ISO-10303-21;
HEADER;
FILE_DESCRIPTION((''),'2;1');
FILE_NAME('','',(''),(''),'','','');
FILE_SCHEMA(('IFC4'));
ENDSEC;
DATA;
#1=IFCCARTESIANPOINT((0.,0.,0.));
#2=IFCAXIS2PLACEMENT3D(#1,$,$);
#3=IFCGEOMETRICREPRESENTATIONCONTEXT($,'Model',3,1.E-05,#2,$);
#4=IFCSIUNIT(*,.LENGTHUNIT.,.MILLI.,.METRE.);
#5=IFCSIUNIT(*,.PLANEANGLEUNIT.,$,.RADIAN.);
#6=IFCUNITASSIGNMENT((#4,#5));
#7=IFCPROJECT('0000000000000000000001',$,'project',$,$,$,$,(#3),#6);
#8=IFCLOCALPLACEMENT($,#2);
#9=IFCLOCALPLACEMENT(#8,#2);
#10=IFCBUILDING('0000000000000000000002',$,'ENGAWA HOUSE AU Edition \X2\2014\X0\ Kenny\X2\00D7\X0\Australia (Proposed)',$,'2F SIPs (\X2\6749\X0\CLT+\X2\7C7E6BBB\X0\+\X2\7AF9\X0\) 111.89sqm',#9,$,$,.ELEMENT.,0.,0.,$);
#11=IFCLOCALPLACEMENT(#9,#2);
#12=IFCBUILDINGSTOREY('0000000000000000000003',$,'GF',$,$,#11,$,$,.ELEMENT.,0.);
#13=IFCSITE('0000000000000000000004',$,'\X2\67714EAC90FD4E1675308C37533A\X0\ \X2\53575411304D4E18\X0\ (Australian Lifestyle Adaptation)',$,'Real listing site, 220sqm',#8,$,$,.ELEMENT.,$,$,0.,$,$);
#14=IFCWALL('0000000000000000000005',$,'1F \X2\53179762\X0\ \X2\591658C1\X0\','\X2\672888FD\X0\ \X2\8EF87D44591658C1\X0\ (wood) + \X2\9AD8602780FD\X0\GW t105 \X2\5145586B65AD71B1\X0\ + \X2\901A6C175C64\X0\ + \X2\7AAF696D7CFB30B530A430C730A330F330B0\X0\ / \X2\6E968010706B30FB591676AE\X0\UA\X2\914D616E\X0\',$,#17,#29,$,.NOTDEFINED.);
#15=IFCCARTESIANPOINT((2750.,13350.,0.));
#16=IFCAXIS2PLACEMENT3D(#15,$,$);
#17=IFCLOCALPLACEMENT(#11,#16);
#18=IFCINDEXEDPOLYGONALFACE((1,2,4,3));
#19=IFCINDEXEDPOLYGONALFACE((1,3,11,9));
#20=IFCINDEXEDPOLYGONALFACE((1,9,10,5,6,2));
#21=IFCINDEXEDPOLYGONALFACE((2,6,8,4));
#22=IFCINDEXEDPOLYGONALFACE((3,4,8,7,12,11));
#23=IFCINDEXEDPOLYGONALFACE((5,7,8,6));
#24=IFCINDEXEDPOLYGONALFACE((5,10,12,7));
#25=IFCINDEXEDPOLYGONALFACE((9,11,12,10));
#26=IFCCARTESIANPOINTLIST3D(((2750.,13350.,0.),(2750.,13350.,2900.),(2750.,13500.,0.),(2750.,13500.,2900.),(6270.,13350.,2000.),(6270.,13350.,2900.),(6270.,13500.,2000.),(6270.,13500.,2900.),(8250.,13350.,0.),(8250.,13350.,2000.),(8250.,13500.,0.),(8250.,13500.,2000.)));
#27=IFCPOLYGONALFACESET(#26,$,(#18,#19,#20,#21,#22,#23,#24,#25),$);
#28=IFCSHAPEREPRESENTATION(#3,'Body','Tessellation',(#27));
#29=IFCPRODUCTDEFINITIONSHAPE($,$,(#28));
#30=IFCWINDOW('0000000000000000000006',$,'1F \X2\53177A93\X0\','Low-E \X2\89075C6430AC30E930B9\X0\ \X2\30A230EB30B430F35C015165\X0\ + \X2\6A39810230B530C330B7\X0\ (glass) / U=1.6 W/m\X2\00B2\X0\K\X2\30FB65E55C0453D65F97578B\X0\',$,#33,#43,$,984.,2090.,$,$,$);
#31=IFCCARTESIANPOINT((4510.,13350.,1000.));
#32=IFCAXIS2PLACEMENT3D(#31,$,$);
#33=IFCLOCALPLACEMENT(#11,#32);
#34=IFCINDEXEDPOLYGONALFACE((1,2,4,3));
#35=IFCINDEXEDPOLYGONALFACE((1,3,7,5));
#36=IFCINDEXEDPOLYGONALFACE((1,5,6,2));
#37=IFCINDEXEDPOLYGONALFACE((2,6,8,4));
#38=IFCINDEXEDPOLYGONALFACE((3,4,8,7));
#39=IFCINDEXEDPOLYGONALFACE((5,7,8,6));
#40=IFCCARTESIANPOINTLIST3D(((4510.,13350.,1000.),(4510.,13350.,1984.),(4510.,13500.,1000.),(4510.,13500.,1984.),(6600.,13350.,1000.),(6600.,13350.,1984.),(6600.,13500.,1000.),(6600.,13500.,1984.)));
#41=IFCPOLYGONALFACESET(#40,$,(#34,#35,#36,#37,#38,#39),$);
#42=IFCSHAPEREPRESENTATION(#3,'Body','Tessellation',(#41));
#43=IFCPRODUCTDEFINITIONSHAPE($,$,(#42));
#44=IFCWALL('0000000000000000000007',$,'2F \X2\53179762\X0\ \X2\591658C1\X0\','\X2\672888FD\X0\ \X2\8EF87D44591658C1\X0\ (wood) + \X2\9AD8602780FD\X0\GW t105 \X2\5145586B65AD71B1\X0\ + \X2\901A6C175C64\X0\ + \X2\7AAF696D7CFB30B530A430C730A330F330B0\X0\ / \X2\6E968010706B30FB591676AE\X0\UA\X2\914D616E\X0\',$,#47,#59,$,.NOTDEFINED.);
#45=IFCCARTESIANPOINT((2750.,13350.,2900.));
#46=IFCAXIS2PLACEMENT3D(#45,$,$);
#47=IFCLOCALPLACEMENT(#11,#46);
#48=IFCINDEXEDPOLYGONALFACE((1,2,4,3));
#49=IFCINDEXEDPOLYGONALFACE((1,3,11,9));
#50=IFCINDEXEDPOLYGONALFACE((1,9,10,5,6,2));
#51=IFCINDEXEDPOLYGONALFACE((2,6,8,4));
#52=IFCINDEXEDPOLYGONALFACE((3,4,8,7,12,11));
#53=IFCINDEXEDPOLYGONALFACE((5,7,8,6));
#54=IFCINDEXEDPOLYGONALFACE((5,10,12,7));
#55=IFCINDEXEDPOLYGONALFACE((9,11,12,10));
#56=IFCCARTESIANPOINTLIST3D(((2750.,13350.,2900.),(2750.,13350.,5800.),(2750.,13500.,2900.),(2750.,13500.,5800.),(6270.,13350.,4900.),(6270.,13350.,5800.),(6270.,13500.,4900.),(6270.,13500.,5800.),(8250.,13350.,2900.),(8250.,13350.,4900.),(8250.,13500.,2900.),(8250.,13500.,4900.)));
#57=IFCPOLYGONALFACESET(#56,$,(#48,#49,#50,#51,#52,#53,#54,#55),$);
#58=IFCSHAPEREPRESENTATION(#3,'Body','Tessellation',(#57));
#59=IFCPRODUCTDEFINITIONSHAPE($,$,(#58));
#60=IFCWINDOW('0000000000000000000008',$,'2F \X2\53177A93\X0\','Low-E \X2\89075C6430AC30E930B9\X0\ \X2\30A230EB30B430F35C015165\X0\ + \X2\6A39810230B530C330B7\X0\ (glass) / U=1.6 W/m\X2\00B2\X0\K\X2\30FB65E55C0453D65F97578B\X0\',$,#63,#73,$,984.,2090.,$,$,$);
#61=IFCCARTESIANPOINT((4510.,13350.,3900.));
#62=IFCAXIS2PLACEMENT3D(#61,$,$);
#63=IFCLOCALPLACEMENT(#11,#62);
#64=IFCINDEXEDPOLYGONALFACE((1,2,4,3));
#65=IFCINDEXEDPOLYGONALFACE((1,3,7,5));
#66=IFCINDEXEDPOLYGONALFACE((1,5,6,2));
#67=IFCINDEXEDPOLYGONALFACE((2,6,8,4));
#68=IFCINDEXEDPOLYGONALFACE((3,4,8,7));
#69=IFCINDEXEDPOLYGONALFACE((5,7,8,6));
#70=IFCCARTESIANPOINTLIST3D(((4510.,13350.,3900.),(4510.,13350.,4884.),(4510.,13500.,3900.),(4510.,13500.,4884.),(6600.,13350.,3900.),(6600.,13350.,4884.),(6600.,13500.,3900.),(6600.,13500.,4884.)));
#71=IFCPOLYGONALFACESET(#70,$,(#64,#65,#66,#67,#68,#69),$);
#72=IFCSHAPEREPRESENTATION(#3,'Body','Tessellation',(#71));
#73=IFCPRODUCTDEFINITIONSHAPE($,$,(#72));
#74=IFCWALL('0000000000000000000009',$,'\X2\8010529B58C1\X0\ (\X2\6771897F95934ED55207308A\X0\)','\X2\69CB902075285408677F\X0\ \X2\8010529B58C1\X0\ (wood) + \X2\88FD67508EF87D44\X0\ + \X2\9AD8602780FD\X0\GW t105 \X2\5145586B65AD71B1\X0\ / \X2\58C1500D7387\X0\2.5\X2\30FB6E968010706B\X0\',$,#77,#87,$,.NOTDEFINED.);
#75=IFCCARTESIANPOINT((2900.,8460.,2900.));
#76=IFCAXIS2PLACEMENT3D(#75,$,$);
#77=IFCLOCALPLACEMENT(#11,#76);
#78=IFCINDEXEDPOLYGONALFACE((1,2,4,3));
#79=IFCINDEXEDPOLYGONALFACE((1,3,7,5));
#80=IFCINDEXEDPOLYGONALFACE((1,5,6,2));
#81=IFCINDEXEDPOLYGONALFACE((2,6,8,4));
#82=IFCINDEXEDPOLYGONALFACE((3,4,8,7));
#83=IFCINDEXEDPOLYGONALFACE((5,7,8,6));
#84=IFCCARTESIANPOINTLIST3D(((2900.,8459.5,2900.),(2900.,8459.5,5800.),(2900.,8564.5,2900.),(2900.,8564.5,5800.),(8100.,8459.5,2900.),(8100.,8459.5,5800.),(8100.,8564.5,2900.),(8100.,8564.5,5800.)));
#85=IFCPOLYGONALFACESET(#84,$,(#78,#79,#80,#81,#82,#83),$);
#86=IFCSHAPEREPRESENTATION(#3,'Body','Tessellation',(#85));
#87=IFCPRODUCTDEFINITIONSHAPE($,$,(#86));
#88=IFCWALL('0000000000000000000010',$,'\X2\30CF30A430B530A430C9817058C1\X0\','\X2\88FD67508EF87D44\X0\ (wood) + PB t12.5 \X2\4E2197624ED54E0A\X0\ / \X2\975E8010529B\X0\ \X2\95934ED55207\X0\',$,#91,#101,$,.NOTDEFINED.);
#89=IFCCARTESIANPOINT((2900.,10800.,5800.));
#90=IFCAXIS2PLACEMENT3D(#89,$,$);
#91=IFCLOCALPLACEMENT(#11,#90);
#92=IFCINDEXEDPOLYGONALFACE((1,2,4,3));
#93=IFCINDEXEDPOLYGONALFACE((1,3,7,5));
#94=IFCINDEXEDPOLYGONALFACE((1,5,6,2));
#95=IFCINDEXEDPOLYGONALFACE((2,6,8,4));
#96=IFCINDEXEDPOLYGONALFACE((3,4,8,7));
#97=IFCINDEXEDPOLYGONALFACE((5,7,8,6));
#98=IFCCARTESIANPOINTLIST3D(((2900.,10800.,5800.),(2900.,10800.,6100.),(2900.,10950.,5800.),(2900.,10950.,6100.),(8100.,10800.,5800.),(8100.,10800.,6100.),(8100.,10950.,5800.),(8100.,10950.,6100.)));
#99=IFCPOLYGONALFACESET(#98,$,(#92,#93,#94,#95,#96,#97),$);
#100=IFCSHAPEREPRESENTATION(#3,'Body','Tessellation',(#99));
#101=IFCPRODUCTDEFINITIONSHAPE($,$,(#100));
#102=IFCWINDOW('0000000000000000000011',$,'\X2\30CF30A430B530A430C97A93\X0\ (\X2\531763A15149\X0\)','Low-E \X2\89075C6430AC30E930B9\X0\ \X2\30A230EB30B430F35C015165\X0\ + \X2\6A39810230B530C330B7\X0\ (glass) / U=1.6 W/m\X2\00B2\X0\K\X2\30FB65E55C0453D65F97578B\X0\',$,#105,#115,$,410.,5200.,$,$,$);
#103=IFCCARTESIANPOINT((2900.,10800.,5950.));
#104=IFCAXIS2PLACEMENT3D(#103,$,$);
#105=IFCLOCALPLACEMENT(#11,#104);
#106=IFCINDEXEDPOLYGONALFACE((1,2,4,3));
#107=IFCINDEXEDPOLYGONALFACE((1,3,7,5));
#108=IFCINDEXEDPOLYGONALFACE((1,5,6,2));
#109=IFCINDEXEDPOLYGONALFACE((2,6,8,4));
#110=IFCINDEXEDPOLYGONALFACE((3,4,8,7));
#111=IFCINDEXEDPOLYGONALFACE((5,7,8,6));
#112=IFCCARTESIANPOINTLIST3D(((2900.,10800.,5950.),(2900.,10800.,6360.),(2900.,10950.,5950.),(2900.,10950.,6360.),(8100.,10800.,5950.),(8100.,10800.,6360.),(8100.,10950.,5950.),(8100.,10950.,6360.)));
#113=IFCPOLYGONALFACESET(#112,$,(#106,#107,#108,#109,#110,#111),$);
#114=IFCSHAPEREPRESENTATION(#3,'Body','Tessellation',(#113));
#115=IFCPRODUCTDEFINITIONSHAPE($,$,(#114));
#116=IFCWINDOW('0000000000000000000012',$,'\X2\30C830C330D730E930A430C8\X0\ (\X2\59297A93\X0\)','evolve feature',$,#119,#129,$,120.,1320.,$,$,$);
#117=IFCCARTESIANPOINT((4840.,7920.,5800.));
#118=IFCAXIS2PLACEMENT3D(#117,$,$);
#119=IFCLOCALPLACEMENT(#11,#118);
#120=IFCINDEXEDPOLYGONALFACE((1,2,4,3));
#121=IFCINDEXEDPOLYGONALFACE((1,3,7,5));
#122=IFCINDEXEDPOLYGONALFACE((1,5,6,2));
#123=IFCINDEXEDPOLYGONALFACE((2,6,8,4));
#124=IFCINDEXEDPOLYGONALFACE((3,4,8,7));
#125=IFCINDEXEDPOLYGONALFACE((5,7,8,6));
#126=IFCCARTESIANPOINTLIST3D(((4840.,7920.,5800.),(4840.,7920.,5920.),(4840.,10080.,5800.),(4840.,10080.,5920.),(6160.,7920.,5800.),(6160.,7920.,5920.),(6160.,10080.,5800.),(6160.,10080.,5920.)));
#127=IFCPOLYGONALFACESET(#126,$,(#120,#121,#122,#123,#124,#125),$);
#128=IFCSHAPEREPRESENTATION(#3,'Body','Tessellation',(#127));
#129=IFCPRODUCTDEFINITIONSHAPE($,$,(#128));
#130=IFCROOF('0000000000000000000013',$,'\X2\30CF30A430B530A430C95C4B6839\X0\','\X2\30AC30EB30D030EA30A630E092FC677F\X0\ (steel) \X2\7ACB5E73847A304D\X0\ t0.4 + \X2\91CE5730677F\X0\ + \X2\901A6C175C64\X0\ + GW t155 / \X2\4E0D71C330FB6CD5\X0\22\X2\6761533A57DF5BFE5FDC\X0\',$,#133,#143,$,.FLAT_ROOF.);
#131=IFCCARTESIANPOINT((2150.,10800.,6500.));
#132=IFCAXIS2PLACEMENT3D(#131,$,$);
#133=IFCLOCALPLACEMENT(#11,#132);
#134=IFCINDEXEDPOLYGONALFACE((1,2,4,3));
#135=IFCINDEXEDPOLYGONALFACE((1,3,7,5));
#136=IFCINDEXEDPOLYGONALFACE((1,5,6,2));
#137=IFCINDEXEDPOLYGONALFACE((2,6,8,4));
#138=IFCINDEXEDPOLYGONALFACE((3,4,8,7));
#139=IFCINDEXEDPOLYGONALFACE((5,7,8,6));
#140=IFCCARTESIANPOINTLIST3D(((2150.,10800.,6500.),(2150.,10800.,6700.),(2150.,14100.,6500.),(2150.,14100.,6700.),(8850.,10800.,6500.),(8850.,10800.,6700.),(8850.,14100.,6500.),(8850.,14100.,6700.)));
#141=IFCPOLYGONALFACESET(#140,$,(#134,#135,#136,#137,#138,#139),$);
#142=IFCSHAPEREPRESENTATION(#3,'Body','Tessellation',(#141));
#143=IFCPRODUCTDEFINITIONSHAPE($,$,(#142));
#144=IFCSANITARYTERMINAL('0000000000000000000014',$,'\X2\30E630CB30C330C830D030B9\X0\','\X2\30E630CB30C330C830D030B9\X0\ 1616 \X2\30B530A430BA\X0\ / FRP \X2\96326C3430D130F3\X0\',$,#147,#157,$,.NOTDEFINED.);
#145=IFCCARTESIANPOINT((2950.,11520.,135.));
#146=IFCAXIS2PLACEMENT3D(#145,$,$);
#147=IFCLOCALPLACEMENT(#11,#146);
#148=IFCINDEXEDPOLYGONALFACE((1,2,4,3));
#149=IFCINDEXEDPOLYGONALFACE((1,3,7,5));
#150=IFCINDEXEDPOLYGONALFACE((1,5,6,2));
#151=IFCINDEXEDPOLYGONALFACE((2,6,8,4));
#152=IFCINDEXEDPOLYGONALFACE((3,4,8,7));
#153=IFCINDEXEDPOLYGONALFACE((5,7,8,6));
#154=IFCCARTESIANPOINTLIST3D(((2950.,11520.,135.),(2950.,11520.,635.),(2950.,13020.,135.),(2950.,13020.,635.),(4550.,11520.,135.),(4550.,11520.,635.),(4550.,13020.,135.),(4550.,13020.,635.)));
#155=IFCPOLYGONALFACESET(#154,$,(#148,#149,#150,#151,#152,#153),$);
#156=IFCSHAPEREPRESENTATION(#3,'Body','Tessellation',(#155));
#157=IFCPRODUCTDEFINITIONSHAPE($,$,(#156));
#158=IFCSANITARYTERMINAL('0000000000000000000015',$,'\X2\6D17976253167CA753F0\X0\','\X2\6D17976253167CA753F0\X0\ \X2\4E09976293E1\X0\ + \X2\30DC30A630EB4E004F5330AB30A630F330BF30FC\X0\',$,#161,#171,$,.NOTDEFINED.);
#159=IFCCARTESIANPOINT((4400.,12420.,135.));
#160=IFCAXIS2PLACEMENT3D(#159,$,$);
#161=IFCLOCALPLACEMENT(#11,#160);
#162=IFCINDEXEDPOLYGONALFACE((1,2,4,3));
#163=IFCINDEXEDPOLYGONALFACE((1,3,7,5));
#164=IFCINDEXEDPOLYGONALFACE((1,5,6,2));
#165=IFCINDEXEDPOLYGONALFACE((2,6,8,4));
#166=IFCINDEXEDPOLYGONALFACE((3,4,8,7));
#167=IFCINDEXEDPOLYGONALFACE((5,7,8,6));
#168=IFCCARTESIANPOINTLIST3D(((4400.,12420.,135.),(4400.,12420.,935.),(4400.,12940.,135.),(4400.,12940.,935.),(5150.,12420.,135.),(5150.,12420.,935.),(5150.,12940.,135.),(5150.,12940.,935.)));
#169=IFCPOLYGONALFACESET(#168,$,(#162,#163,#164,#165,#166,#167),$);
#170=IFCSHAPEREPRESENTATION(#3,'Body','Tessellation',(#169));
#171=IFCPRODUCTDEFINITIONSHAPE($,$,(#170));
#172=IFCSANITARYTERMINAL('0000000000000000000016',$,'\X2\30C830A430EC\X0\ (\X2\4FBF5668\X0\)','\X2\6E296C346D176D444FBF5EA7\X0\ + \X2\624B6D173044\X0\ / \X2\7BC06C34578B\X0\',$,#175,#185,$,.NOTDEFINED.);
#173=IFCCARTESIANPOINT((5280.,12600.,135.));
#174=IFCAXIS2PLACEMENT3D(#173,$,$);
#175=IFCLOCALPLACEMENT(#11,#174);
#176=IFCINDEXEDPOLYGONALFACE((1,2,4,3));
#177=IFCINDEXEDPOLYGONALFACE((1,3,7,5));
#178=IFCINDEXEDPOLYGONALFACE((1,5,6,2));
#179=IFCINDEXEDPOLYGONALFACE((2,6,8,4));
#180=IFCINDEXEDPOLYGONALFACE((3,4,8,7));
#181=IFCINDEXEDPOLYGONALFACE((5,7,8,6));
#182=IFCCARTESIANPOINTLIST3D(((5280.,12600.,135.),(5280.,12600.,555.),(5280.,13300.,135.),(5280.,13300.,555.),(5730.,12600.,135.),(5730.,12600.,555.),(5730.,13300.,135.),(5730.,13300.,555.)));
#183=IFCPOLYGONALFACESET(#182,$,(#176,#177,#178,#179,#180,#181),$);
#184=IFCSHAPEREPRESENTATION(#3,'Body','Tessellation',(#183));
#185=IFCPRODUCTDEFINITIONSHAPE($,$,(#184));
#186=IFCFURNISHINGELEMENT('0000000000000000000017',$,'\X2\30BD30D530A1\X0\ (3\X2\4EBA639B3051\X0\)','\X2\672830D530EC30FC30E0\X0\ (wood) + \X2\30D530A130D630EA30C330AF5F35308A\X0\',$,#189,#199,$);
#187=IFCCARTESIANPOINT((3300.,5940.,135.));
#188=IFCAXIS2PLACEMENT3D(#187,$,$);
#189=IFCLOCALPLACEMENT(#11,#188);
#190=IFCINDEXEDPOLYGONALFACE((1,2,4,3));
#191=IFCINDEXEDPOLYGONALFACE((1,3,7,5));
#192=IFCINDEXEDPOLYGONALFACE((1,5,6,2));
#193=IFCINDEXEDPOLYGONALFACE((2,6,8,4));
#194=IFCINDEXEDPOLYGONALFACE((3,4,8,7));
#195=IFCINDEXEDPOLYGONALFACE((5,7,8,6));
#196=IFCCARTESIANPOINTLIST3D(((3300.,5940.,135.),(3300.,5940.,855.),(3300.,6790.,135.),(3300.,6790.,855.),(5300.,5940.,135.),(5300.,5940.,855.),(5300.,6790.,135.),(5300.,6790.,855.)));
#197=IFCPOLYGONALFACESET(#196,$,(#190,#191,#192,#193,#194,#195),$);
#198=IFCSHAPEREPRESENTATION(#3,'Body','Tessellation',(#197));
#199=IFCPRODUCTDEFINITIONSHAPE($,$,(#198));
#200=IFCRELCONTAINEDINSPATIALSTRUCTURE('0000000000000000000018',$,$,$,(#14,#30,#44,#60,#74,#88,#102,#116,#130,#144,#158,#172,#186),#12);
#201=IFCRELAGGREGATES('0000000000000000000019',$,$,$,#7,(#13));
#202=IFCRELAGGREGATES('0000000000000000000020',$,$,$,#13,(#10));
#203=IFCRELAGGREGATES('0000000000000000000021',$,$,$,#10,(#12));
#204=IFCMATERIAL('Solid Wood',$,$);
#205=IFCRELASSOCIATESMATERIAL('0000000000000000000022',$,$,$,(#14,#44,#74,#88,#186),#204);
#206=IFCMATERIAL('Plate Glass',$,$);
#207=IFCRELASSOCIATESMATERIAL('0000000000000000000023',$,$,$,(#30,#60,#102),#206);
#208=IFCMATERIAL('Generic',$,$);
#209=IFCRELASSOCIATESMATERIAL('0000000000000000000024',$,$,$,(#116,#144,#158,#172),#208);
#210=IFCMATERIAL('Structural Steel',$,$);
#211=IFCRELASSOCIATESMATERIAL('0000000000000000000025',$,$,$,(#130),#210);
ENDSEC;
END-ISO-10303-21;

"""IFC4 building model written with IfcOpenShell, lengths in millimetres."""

from ifc_helpers import new_model, si_unit, frame, frame_2d, origin, place, context, project, spatial, rectangle, extrude, material, element, fill, save


model = new_model("IFC4")

# Units and contexts
model_context = context("Model", 3, precision=1e-05, world=origin())
ifc_project = project(units=[si_unit("LENGTHUNIT", "METRE", prefix="MILLI"), si_unit("PLANEANGLEUNIT", "RADIAN")], contexts=[model_context])

# Site, building, storey
site_placement = place(None, origin())
site = spatial("IfcSite", under=ifc_project, at=site_placement, Name="東京都世田谷区 南向き丘 (Australian Lifestyle Adaptation)", ObjectType="Real listing site, 220sqm", CompositionType="ELEMENT", RefElevation=0.0)
building_placement = place(site_placement, origin())
building = spatial("IfcBuilding", under=site, at=building_placement, Name="ENGAWA HOUSE AU Edition — Kenny×Australia (Proposed)", ObjectType="2F SIPs (杉CLT+籾殻+竹) 111.89sqm", CompositionType="ELEMENT", ElevationOfRefHeight=0.0, ElevationOfTerrain=0.0)
storey_placement = place(building_placement, origin())
storey = spatial("IfcBuildingStorey", under=building, at=storey_placement, Name="GF", CompositionType="ELEMENT", Elevation=0.0)

# Wall, opening, window
ifc_material_1 = material(Name="Solid Wood")
wall_1_placement = place(storey_placement, frame((2750.0, 13350.0, 0.0)))
wall_1 = element("IfcWall", 1, at=wall_1_placement, inside=storey, material=ifc_material_1, Name="1F 北面 外壁", Description="木製 軸組外壁 (wood) + 高性能GW t105 充填断熱 + 通気層 + 窯業系サイディング / 準耐火・外皮UA配慮", PredefinedType="NOTDEFINED", context=model_context, shape_type="SweptSolid", body=[
    extrude(rectangle(XDim=5500.0, YDim=150.0, at=frame_2d((2750.0, 75.0))), frame((2750.0, 13350.0, 0.0)), (0.0, 0.0, 1.0), 2900.0),
])
opening_1_placement = place(storey_placement, frame((4510.0, 13350.0, 1000.0)))
opening_1 = element("IfcOpeningElement", 2, at=opening_1_placement, cuts=wall_1, PredefinedType="NOTDEFINED", context=model_context, shape_type="SweptSolid", body=[
    extrude(rectangle(XDim=2090.0, YDim=150.0, at=frame_2d((1045.0, 75.0))), frame((4510.0, 13350.0, 1000.0)), (0.0, 0.0, 1.0), 984.0),
])
ifc_material_2 = material(Name="Plate Glass")
window_1_placement = place(storey_placement, frame((4510.0, 13350.0, 1000.0)))
window_1 = element("IfcWindow", 3, at=window_1_placement, inside=storey, material=ifc_material_2, Name="1F 北窓", Description="Low-E 複層ガラス アルゴン封入 + 樹脂サッシ (glass) / U=1.6 W/m²K・日射取得型", OverallHeight=984.0, OverallWidth=2090.0, context=model_context, shape_type="SweptSolid", body=[
    extrude(rectangle(XDim=2090.0, YDim=150.0, at=frame_2d((1045.0, 75.0))), frame((4510.0, 13350.0, 1000.0)), (0.0, 0.0, 1.0), 984.0),
])
fill(opening_1, window_1)

# Wall, opening, window
wall_2_placement = place(storey_placement, frame((2750.0, 13350.0, 2900.0)))
wall_2 = element("IfcWall", 4, at=wall_2_placement, inside=storey, material=ifc_material_1, Name="2F 北面 外壁", Description="木製 軸組外壁 (wood) + 高性能GW t105 充填断熱 + 通気層 + 窯業系サイディング / 準耐火・外皮UA配慮", PredefinedType="NOTDEFINED", context=model_context, shape_type="SweptSolid", body=[
    extrude(rectangle(XDim=5500.0, YDim=150.0, at=frame_2d((2750.0, 75.0))), frame((2750.0, 13350.0, 2900.0)), (0.0, 0.0, 1.0), 2900.0),
])
opening_2_placement = place(storey_placement, frame((4510.0, 13350.0, 3900.0)))
opening_2 = element("IfcOpeningElement", 5, at=opening_2_placement, cuts=wall_2, PredefinedType="NOTDEFINED", context=model_context, shape_type="SweptSolid", body=[
    extrude(rectangle(XDim=2090.0, YDim=150.0, at=frame_2d((1045.0, 75.0))), frame((4510.0, 13350.0, 3900.0)), (0.0, 0.0, 1.0), 984.0),
])
window_2_placement = place(storey_placement, frame((4510.0, 13350.0, 3900.0)))
window_2 = element("IfcWindow", 6, at=window_2_placement, inside=storey, material=ifc_material_2, Name="2F 北窓", Description="Low-E 複層ガラス アルゴン封入 + 樹脂サッシ (glass) / U=1.6 W/m²K・日射取得型", OverallHeight=984.0, OverallWidth=2090.0, context=model_context, shape_type="SweptSolid", body=[
    extrude(rectangle(XDim=2090.0, YDim=150.0, at=frame_2d((1045.0, 75.0))), frame((4510.0, 13350.0, 3900.0)), (0.0, 0.0, 1.0), 984.0),
])
fill(opening_2, window_2)

# Wall
wall_3_placement = place(storey_placement, frame((2900.0, 8460.0, 2900.0)))
element("IfcWall", 7, at=wall_3_placement, inside=storey, material=ifc_material_1, Name="耐力壁 (東西間仕切り)", Description="構造用合板 耐力壁 (wood) + 製材軸組 + 高性能GW t105 充填断熱 / 壁倍率2.5・準耐火", PredefinedType="NOTDEFINED", context=model_context, shape_type="SweptSolid", body=[
    extrude(rectangle(XDim=5200.0, YDim=105.0, at=frame_2d((2600.0, 52.0))), frame((2900.0, 8460.0, 2900.0)), (0.0, 0.0, 1.0), 2900.0),
])

# Wall, opening, window
wall_4_placement = place(storey_placement, frame((2900.0, 10800.0, 5800.0)))
wall_4 = element("IfcWall", 8, at=wall_4_placement, inside=storey, material=ifc_material_1, Name="ハイサイド腰壁", Description="製材軸組 (wood) + PB t12.5 両面仕上 / 非耐力 間仕切", PredefinedType="NOTDEFINED", context=model_context, shape_type="SweptSolid", body=[
    extrude(rectangle(XDim=5200.0, YDim=150.0, at=frame_2d((2600.0, 75.0))), frame((2900.0, 10800.0, 5800.0)), (0.0, 0.0, 1.0), 700.0),
])
opening_3_placement = place(storey_placement, frame((2900.0, 10800.0, 5950.0)))
opening_3 = element("IfcOpeningElement", 9, at=opening_3_placement, cuts=wall_4, PredefinedType="NOTDEFINED", context=model_context, shape_type="SweptSolid", body=[
    extrude(rectangle(XDim=5200.0, YDim=150.0, at=frame_2d((2600.0, 75.0))), frame((2900.0, 10800.0, 5950.0)), (0.0, 0.0, 1.0), 410.0),
])
window_3_placement = place(storey_placement, frame((2900.0, 10800.0, 5950.0)))
window_3 = element("IfcWindow", 10, at=window_3_placement, inside=storey, material=ifc_material_2, Name="ハイサイド窓 (北採光)", Description="Low-E 複層ガラス アルゴン封入 + 樹脂サッシ (glass) / U=1.6 W/m²K・日射取得型", OverallHeight=410.0, OverallWidth=5200.0, context=model_context, shape_type="SweptSolid", body=[
    extrude(rectangle(XDim=5200.0, YDim=150.0, at=frame_2d((2600.0, 75.0))), frame((2900.0, 10800.0, 5950.0)), (0.0, 0.0, 1.0), 410.0),
])
fill(opening_3, window_3)

# Window
ifc_material_3 = material(Name="Generic")
window_4_placement = place(storey_placement, frame((4840.0, 7920.0, 5800.0)))
element("IfcWindow", 11, at=window_4_placement, inside=storey, material=ifc_material_3, Name="トップライト (天窓)", Description="evolve feature", OverallHeight=120.0, OverallWidth=1320.0, context=model_context, shape_type="SweptSolid", body=[
    extrude(rectangle(XDim=1320.0, YDim=2160.0, at=frame_2d((660.0, 1080.0))), frame((4840.0, 7920.0, 5800.0)), (0.0, 0.0, 1.0), 120.0),
])

# Roof
ifc_material_4 = material(Name="Structural Steel")
roof_placement = place(storey_placement, frame((2150.0, 10800.0, 6500.0)))
element("IfcRoof", 12, at=roof_placement, inside=storey, material=ifc_material_4, Name="ハイサイド屋根", Description="ガルバリウム鋼板 (steel) 立平葺き t0.4 + 野地板 + 通気層 + GW t155 / 不燃・法22条区域対応", PredefinedType="FLAT_ROOF", context=model_context, shape_type="SweptSolid", body=[
    extrude(rectangle(XDim=6700.0, YDim=3300.0, at=frame_2d((3350.0, 1650.0))), frame((2150.0, 10800.0, 6500.0)), (0.0, 0.0, 1.0), 200.0),
])

# Sanitary terminals
sanitary_terminal_1_placement = place(storey_placement, frame((2950.0, 11520.0, 135.0)))
element("IfcSanitaryTerminal", 13, at=sanitary_terminal_1_placement, inside=storey, material=ifc_material_3, Name="ユニットバス", Description="ユニットバス 1616 サイズ / FRP 防水パン", PredefinedType="NOTDEFINED", context=model_context, shape_type="SweptSolid", body=[
    extrude(rectangle(XDim=1600.0, YDim=1500.0, at=frame_2d((800.0, 750.0))), frame((2950.0, 11520.0, 135.0)), (0.0, 0.0, 1.0), 500.0),
])
sanitary_terminal_2_placement = place(storey_placement, frame((4400.0, 12420.0, 135.0)))
element("IfcSanitaryTerminal", 14, at=sanitary_terminal_2_placement, inside=storey, material=ifc_material_3, Name="洗面化粧台", Description="洗面化粧台 三面鏡 + ボウル一体カウンター", PredefinedType="NOTDEFINED", context=model_context, shape_type="SweptSolid", body=[
    extrude(rectangle(XDim=750.0, YDim=520.0, at=frame_2d((375.0, 260.0))), frame((4400.0, 12420.0, 135.0)), (0.0, 0.0, 1.0), 800.0),
])
sanitary_terminal_3_placement = place(storey_placement, frame((5280.0, 12600.0, 135.0)))
element("IfcSanitaryTerminal", 15, at=sanitary_terminal_3_placement, inside=storey, material=ifc_material_3, Name="トイレ (便器)", Description="温水洗浄便座 + 手洗い / 節水型", PredefinedType="NOTDEFINED", context=model_context, shape_type="SweptSolid", body=[
    extrude(rectangle(XDim=450.0, YDim=700.0, at=frame_2d((225.0, 350.0))), frame((5280.0, 12600.0, 135.0)), (0.0, 0.0, 1.0), 420.0),
])

# Furnishing element
furnishing_1_placement = place(storey_placement, frame((3300.0, 5940.0, 135.0)))
element("IfcFurnishingElement", 16, at=furnishing_1_placement, inside=storey, material=ifc_material_1, Name="ソファ (3人掛け)", Description="木フレーム (wood) + ファブリック張り", context=model_context, shape_type="SweptSolid", body=[
    extrude(rectangle(XDim=2000.0, YDim=850.0, at=frame_2d((1000.0, 425.0))), frame((3300.0, 5940.0, 135.0)), (0.0, 0.0, 1.0), 720.0),
])

save(model, "model.ifc")
